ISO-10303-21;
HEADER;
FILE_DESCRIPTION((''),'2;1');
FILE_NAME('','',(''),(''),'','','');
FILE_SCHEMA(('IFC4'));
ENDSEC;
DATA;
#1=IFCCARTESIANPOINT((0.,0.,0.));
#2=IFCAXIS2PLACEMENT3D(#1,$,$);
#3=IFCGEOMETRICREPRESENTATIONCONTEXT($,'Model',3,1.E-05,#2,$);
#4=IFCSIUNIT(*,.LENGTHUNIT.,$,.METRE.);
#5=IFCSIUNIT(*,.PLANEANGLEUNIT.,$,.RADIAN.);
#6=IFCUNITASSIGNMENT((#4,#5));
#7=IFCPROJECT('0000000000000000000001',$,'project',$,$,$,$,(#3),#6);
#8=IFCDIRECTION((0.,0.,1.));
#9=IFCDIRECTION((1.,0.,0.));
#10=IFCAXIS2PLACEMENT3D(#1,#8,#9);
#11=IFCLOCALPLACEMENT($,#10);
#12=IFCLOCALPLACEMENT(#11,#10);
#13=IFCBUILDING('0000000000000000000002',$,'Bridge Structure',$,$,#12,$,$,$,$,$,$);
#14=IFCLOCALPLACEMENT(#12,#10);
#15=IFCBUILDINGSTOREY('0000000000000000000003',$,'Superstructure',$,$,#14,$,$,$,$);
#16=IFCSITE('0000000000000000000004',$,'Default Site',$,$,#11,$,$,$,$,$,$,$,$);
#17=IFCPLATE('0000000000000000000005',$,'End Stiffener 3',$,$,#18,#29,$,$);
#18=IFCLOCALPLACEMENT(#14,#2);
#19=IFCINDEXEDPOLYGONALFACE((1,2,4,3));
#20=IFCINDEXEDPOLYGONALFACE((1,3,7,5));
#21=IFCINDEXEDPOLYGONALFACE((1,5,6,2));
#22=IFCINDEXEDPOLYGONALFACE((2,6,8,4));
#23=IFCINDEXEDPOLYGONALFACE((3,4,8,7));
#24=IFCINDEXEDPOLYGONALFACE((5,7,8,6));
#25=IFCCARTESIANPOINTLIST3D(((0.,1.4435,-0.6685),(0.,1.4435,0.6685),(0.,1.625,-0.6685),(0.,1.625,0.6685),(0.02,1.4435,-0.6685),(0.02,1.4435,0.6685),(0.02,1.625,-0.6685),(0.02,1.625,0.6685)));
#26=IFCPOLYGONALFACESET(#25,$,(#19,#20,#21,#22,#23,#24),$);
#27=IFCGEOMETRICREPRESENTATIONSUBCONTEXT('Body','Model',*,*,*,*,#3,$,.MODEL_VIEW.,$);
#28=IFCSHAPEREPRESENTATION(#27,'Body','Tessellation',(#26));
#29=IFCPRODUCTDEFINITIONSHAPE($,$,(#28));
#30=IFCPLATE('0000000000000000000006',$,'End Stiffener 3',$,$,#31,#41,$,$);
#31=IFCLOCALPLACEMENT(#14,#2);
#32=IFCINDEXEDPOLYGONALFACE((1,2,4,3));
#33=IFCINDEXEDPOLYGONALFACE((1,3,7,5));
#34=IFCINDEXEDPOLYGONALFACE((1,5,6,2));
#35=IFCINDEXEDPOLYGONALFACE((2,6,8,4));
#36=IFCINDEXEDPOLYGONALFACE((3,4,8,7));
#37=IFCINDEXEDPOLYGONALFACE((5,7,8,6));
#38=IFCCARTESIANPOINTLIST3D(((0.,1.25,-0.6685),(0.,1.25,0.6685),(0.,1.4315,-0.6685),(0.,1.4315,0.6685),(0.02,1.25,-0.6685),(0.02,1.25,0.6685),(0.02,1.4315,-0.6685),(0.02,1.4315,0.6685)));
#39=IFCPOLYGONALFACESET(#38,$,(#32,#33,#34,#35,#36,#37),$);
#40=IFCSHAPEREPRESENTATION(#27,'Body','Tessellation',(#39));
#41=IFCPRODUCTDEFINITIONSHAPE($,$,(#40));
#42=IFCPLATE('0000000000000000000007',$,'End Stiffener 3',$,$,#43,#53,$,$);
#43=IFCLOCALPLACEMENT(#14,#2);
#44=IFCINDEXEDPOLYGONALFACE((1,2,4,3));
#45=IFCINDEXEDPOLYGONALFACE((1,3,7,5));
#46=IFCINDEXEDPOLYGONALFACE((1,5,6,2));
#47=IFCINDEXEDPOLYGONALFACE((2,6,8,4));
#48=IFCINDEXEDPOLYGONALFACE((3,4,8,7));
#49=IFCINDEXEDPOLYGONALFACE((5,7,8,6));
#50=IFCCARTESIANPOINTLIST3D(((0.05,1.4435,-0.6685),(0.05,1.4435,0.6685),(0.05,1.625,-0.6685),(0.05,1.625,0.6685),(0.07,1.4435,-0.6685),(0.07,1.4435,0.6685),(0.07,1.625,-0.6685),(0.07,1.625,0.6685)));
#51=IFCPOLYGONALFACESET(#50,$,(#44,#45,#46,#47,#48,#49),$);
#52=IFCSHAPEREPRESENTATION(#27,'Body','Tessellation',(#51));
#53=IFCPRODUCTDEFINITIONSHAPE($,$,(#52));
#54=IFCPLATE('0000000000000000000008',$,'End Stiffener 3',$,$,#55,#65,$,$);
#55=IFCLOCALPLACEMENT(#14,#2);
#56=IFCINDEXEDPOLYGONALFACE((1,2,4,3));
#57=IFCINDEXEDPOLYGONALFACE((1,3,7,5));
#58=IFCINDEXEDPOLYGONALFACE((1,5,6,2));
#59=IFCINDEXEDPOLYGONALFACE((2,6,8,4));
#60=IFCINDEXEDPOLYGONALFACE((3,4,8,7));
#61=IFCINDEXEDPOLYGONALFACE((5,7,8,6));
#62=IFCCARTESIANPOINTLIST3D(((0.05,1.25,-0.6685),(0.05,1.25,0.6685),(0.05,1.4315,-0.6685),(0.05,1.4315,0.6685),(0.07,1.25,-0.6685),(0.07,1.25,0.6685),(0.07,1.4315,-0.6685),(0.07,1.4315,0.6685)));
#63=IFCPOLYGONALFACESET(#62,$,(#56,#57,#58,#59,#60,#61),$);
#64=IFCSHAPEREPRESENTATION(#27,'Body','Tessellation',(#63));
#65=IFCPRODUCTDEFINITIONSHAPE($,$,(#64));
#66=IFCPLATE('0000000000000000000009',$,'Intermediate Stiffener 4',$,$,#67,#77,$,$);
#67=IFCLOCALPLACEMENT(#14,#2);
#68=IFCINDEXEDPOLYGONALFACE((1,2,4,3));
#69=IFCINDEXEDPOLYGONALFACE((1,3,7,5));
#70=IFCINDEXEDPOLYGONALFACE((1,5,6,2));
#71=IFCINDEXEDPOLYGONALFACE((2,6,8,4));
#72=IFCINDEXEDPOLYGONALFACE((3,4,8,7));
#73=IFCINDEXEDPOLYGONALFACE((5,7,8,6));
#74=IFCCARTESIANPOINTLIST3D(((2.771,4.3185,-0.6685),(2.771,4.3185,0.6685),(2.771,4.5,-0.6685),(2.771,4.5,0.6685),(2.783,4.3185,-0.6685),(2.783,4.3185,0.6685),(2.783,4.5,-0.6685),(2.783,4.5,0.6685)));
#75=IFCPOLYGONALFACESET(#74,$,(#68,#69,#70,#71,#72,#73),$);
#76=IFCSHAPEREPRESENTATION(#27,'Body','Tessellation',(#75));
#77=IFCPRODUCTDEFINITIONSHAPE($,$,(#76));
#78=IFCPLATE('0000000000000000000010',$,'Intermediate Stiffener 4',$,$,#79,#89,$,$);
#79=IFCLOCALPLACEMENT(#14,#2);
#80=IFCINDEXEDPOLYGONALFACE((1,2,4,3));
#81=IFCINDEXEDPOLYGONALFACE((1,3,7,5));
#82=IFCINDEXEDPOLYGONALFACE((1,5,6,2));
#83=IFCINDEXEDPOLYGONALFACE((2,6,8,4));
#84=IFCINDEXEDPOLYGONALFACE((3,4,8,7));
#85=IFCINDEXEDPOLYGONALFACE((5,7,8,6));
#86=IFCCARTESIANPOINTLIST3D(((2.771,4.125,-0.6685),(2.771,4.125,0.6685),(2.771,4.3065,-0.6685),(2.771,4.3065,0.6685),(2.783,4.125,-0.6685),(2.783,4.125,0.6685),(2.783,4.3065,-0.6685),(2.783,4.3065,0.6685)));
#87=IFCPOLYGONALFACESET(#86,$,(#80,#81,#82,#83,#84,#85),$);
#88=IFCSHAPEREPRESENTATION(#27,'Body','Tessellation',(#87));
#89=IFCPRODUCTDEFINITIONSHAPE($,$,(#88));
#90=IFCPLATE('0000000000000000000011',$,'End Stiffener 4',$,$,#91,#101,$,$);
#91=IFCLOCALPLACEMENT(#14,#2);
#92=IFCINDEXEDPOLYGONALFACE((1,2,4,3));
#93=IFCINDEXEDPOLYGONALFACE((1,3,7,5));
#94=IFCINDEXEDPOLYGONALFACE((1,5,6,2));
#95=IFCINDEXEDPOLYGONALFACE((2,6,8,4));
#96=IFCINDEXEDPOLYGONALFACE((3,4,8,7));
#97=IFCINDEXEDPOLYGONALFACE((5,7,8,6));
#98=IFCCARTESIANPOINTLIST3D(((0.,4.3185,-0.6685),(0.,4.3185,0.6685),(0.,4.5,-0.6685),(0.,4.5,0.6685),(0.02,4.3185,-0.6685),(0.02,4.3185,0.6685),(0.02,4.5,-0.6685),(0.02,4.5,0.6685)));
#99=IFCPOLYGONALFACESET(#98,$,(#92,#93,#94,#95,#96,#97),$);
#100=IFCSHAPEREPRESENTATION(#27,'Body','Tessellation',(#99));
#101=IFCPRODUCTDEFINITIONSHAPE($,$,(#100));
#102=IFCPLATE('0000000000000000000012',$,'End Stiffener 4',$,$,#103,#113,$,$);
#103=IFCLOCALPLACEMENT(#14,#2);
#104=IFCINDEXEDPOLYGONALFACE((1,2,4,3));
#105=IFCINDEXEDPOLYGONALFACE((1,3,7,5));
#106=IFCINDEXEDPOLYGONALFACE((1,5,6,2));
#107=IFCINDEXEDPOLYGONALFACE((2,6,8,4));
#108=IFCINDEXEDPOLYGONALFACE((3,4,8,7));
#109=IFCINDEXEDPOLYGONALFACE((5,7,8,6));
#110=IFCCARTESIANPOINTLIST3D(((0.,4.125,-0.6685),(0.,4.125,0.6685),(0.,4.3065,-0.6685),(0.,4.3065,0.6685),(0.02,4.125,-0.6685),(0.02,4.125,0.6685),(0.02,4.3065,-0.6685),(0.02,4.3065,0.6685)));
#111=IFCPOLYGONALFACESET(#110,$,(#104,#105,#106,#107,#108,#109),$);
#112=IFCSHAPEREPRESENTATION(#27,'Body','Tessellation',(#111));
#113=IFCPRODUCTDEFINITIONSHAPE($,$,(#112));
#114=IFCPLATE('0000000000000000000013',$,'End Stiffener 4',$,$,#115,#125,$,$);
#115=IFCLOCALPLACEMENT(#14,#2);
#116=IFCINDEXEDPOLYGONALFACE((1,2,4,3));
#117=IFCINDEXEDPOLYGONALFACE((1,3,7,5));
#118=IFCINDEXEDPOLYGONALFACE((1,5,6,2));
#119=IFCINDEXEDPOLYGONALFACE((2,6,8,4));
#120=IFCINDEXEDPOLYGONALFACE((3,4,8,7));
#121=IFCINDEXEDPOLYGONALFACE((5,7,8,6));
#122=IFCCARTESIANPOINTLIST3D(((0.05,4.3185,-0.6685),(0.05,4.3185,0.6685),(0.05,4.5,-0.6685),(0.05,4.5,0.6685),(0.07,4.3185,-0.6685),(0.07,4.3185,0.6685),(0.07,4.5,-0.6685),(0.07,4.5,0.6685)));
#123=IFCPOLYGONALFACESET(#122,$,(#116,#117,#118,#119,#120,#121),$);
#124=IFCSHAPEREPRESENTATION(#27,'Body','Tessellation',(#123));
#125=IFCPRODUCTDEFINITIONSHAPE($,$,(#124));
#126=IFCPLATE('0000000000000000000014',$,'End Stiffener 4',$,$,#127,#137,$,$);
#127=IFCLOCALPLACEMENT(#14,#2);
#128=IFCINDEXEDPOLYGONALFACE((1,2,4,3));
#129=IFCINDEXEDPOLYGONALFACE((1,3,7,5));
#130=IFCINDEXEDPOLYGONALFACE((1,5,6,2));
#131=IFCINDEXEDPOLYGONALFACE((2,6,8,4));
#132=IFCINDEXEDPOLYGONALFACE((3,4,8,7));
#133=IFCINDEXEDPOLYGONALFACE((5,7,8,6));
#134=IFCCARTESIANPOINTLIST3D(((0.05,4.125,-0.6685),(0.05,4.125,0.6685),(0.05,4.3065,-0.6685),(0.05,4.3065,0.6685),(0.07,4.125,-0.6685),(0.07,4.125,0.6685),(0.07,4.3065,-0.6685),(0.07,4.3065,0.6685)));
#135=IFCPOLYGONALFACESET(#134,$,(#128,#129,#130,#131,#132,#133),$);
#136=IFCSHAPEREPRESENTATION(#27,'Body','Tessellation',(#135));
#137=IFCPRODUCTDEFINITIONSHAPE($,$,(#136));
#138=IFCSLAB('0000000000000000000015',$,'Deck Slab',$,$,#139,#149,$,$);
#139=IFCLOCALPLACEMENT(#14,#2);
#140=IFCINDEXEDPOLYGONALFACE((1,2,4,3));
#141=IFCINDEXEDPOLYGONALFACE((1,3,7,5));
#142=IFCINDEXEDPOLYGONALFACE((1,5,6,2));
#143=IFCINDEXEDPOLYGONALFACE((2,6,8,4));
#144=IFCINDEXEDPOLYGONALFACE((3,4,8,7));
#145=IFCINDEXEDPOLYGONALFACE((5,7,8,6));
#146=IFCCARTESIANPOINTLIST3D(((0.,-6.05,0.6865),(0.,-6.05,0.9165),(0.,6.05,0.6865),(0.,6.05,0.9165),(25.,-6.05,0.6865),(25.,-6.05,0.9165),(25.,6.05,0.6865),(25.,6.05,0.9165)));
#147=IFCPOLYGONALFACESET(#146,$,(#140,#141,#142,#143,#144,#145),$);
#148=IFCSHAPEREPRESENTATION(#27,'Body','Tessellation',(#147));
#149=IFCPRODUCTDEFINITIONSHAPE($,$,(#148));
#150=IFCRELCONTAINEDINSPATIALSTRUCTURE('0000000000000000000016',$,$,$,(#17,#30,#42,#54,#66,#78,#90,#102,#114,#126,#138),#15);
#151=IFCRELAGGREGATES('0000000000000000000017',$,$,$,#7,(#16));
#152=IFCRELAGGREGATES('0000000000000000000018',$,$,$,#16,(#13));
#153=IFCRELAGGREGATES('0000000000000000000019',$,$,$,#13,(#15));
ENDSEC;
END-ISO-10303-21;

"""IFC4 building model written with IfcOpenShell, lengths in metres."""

from ifc_helpers import new_model, si_unit, frame, origin, origin_with_axes, origin_2d_with_axis, place, context, subcontext, project, spatial, polyline, rectangle, outline, extrude, element, save


model = new_model("IFC4")

# Units and contexts
model_context = context("Model", 3, precision=1e-05, world=origin())
body_context = subcontext(model_context, "Body", "Model", "MODEL_VIEW")
ifc_project = project(units=[si_unit("LENGTHUNIT", "METRE"), si_unit("PLANEANGLEUNIT", "RADIAN")], contexts=[model_context])

# Site, building, storey
site_placement = place(None, origin_with_axes())
site = spatial("IfcSite", under=ifc_project, at=site_placement, Name="Default Site")
building_placement = place(site_placement, origin_with_axes())
building = spatial("IfcBuilding", under=site, at=building_placement, Name="Bridge Structure")
storey_placement = place(building_placement, origin_with_axes())
storey = spatial("IfcBuildingStorey", under=building, at=storey_placement, Name="Superstructure")

# Plates
for number, where, z_axis, x_axis, name in (
    (1, (0.01, 1.5343, -0.6685), (0.0, 0.0, 1.0), (1.0, 0.0, 0.0), "End Stiffener 3"),
    (2, (0.01, 1.3408, -0.6685), (0.0, 0.0, 1.0), (1.0, 0.0, 0.0), "End Stiffener 3"),
    (3, (0.06, 1.5343, -0.6685), (0.0, 0.0, 1.0), (1.0, 0.0, 0.0), "End Stiffener 3"),
    (4, (0.06, 1.3408, -0.6685), (0.0, 0.0, 1.0), (1.0, 0.0, 0.0), "End Stiffener 3"),
):
    element("IfcPlate", number, at=place(storey_placement, frame(where, z_axis=z_axis, x_axis=x_axis)), inside=storey, Name=name, context=body_context, shape_type="SweptSolid", body=[
        extrude(rectangle(XDim=0.02, YDim=0.1815, at=origin_2d_with_axis()), origin_with_axes(), (0.0, 0.0, 1.0), 1.337),
    ])
for number, where, z_axis, x_axis, name in (
    (5, (2.777, 4.4093, -0.6685), (0.0, 0.0, 1.0), (1.0, 0.0, 0.0), "Intermediate Stiffener 4"),
    (6, (2.777, 4.2157, -0.6685), (0.0, 0.0, 1.0), (1.0, 0.0, 0.0), "Intermediate Stiffener 4"),
):
    element("IfcPlate", number, at=place(storey_placement, frame(where, z_axis=z_axis, x_axis=x_axis)), inside=storey, Name=name, context=body_context, shape_type="SweptSolid", body=[
        extrude(rectangle(XDim=0.012, YDim=0.1815, at=origin_2d_with_axis()), origin_with_axes(), (0.0, 0.0, 1.0), 1.337),
    ])
for number, where, z_axis, x_axis, name in (
    (7, (0.01, 4.4093, -0.6685), (0.0, 0.0, 1.0), (1.0, 0.0, 0.0), "End Stiffener 4"),
    (8, (0.01, 4.2157, -0.6685), (0.0, 0.0, 1.0), (1.0, 0.0, 0.0), "End Stiffener 4"),
    (9, (0.06, 4.4093, -0.6685), (0.0, 0.0, 1.0), (1.0, 0.0, 0.0), "End Stiffener 4"),
    (10, (0.06, 4.2157, -0.6685), (0.0, 0.0, 1.0), (1.0, 0.0, 0.0), "End Stiffener 4"),
):
    element("IfcPlate", number, at=place(storey_placement, frame(where, z_axis=z_axis, x_axis=x_axis)), inside=storey, Name=name, context=body_context, shape_type="SweptSolid", body=[
        extrude(rectangle(XDim=0.02, YDim=0.1815, at=origin_2d_with_axis()), origin_with_axes(), (0.0, 0.0, 1.0), 1.337),
    ])

# Slab
slab_placement = place(storey_placement, frame((0.0, 0.0, 0.6865), z_axis=(0.0, 0.0, 1.0), x_axis=(1.0, 0.0, 0.0)))
element("IfcSlab", 11, at=slab_placement, inside=storey, Name="Deck Slab", context=body_context, shape_type="SweptSolid", body=[
    extrude(outline(polyline([(0.0, -6.05), (25.0, -6.05), (25.0, 6.05), (0.0, 6.05), (0.0, -6.05)])), origin_with_axes(), (0.0, 0.0, 1.0), 0.23),
])

save(model, "model.ifc")
